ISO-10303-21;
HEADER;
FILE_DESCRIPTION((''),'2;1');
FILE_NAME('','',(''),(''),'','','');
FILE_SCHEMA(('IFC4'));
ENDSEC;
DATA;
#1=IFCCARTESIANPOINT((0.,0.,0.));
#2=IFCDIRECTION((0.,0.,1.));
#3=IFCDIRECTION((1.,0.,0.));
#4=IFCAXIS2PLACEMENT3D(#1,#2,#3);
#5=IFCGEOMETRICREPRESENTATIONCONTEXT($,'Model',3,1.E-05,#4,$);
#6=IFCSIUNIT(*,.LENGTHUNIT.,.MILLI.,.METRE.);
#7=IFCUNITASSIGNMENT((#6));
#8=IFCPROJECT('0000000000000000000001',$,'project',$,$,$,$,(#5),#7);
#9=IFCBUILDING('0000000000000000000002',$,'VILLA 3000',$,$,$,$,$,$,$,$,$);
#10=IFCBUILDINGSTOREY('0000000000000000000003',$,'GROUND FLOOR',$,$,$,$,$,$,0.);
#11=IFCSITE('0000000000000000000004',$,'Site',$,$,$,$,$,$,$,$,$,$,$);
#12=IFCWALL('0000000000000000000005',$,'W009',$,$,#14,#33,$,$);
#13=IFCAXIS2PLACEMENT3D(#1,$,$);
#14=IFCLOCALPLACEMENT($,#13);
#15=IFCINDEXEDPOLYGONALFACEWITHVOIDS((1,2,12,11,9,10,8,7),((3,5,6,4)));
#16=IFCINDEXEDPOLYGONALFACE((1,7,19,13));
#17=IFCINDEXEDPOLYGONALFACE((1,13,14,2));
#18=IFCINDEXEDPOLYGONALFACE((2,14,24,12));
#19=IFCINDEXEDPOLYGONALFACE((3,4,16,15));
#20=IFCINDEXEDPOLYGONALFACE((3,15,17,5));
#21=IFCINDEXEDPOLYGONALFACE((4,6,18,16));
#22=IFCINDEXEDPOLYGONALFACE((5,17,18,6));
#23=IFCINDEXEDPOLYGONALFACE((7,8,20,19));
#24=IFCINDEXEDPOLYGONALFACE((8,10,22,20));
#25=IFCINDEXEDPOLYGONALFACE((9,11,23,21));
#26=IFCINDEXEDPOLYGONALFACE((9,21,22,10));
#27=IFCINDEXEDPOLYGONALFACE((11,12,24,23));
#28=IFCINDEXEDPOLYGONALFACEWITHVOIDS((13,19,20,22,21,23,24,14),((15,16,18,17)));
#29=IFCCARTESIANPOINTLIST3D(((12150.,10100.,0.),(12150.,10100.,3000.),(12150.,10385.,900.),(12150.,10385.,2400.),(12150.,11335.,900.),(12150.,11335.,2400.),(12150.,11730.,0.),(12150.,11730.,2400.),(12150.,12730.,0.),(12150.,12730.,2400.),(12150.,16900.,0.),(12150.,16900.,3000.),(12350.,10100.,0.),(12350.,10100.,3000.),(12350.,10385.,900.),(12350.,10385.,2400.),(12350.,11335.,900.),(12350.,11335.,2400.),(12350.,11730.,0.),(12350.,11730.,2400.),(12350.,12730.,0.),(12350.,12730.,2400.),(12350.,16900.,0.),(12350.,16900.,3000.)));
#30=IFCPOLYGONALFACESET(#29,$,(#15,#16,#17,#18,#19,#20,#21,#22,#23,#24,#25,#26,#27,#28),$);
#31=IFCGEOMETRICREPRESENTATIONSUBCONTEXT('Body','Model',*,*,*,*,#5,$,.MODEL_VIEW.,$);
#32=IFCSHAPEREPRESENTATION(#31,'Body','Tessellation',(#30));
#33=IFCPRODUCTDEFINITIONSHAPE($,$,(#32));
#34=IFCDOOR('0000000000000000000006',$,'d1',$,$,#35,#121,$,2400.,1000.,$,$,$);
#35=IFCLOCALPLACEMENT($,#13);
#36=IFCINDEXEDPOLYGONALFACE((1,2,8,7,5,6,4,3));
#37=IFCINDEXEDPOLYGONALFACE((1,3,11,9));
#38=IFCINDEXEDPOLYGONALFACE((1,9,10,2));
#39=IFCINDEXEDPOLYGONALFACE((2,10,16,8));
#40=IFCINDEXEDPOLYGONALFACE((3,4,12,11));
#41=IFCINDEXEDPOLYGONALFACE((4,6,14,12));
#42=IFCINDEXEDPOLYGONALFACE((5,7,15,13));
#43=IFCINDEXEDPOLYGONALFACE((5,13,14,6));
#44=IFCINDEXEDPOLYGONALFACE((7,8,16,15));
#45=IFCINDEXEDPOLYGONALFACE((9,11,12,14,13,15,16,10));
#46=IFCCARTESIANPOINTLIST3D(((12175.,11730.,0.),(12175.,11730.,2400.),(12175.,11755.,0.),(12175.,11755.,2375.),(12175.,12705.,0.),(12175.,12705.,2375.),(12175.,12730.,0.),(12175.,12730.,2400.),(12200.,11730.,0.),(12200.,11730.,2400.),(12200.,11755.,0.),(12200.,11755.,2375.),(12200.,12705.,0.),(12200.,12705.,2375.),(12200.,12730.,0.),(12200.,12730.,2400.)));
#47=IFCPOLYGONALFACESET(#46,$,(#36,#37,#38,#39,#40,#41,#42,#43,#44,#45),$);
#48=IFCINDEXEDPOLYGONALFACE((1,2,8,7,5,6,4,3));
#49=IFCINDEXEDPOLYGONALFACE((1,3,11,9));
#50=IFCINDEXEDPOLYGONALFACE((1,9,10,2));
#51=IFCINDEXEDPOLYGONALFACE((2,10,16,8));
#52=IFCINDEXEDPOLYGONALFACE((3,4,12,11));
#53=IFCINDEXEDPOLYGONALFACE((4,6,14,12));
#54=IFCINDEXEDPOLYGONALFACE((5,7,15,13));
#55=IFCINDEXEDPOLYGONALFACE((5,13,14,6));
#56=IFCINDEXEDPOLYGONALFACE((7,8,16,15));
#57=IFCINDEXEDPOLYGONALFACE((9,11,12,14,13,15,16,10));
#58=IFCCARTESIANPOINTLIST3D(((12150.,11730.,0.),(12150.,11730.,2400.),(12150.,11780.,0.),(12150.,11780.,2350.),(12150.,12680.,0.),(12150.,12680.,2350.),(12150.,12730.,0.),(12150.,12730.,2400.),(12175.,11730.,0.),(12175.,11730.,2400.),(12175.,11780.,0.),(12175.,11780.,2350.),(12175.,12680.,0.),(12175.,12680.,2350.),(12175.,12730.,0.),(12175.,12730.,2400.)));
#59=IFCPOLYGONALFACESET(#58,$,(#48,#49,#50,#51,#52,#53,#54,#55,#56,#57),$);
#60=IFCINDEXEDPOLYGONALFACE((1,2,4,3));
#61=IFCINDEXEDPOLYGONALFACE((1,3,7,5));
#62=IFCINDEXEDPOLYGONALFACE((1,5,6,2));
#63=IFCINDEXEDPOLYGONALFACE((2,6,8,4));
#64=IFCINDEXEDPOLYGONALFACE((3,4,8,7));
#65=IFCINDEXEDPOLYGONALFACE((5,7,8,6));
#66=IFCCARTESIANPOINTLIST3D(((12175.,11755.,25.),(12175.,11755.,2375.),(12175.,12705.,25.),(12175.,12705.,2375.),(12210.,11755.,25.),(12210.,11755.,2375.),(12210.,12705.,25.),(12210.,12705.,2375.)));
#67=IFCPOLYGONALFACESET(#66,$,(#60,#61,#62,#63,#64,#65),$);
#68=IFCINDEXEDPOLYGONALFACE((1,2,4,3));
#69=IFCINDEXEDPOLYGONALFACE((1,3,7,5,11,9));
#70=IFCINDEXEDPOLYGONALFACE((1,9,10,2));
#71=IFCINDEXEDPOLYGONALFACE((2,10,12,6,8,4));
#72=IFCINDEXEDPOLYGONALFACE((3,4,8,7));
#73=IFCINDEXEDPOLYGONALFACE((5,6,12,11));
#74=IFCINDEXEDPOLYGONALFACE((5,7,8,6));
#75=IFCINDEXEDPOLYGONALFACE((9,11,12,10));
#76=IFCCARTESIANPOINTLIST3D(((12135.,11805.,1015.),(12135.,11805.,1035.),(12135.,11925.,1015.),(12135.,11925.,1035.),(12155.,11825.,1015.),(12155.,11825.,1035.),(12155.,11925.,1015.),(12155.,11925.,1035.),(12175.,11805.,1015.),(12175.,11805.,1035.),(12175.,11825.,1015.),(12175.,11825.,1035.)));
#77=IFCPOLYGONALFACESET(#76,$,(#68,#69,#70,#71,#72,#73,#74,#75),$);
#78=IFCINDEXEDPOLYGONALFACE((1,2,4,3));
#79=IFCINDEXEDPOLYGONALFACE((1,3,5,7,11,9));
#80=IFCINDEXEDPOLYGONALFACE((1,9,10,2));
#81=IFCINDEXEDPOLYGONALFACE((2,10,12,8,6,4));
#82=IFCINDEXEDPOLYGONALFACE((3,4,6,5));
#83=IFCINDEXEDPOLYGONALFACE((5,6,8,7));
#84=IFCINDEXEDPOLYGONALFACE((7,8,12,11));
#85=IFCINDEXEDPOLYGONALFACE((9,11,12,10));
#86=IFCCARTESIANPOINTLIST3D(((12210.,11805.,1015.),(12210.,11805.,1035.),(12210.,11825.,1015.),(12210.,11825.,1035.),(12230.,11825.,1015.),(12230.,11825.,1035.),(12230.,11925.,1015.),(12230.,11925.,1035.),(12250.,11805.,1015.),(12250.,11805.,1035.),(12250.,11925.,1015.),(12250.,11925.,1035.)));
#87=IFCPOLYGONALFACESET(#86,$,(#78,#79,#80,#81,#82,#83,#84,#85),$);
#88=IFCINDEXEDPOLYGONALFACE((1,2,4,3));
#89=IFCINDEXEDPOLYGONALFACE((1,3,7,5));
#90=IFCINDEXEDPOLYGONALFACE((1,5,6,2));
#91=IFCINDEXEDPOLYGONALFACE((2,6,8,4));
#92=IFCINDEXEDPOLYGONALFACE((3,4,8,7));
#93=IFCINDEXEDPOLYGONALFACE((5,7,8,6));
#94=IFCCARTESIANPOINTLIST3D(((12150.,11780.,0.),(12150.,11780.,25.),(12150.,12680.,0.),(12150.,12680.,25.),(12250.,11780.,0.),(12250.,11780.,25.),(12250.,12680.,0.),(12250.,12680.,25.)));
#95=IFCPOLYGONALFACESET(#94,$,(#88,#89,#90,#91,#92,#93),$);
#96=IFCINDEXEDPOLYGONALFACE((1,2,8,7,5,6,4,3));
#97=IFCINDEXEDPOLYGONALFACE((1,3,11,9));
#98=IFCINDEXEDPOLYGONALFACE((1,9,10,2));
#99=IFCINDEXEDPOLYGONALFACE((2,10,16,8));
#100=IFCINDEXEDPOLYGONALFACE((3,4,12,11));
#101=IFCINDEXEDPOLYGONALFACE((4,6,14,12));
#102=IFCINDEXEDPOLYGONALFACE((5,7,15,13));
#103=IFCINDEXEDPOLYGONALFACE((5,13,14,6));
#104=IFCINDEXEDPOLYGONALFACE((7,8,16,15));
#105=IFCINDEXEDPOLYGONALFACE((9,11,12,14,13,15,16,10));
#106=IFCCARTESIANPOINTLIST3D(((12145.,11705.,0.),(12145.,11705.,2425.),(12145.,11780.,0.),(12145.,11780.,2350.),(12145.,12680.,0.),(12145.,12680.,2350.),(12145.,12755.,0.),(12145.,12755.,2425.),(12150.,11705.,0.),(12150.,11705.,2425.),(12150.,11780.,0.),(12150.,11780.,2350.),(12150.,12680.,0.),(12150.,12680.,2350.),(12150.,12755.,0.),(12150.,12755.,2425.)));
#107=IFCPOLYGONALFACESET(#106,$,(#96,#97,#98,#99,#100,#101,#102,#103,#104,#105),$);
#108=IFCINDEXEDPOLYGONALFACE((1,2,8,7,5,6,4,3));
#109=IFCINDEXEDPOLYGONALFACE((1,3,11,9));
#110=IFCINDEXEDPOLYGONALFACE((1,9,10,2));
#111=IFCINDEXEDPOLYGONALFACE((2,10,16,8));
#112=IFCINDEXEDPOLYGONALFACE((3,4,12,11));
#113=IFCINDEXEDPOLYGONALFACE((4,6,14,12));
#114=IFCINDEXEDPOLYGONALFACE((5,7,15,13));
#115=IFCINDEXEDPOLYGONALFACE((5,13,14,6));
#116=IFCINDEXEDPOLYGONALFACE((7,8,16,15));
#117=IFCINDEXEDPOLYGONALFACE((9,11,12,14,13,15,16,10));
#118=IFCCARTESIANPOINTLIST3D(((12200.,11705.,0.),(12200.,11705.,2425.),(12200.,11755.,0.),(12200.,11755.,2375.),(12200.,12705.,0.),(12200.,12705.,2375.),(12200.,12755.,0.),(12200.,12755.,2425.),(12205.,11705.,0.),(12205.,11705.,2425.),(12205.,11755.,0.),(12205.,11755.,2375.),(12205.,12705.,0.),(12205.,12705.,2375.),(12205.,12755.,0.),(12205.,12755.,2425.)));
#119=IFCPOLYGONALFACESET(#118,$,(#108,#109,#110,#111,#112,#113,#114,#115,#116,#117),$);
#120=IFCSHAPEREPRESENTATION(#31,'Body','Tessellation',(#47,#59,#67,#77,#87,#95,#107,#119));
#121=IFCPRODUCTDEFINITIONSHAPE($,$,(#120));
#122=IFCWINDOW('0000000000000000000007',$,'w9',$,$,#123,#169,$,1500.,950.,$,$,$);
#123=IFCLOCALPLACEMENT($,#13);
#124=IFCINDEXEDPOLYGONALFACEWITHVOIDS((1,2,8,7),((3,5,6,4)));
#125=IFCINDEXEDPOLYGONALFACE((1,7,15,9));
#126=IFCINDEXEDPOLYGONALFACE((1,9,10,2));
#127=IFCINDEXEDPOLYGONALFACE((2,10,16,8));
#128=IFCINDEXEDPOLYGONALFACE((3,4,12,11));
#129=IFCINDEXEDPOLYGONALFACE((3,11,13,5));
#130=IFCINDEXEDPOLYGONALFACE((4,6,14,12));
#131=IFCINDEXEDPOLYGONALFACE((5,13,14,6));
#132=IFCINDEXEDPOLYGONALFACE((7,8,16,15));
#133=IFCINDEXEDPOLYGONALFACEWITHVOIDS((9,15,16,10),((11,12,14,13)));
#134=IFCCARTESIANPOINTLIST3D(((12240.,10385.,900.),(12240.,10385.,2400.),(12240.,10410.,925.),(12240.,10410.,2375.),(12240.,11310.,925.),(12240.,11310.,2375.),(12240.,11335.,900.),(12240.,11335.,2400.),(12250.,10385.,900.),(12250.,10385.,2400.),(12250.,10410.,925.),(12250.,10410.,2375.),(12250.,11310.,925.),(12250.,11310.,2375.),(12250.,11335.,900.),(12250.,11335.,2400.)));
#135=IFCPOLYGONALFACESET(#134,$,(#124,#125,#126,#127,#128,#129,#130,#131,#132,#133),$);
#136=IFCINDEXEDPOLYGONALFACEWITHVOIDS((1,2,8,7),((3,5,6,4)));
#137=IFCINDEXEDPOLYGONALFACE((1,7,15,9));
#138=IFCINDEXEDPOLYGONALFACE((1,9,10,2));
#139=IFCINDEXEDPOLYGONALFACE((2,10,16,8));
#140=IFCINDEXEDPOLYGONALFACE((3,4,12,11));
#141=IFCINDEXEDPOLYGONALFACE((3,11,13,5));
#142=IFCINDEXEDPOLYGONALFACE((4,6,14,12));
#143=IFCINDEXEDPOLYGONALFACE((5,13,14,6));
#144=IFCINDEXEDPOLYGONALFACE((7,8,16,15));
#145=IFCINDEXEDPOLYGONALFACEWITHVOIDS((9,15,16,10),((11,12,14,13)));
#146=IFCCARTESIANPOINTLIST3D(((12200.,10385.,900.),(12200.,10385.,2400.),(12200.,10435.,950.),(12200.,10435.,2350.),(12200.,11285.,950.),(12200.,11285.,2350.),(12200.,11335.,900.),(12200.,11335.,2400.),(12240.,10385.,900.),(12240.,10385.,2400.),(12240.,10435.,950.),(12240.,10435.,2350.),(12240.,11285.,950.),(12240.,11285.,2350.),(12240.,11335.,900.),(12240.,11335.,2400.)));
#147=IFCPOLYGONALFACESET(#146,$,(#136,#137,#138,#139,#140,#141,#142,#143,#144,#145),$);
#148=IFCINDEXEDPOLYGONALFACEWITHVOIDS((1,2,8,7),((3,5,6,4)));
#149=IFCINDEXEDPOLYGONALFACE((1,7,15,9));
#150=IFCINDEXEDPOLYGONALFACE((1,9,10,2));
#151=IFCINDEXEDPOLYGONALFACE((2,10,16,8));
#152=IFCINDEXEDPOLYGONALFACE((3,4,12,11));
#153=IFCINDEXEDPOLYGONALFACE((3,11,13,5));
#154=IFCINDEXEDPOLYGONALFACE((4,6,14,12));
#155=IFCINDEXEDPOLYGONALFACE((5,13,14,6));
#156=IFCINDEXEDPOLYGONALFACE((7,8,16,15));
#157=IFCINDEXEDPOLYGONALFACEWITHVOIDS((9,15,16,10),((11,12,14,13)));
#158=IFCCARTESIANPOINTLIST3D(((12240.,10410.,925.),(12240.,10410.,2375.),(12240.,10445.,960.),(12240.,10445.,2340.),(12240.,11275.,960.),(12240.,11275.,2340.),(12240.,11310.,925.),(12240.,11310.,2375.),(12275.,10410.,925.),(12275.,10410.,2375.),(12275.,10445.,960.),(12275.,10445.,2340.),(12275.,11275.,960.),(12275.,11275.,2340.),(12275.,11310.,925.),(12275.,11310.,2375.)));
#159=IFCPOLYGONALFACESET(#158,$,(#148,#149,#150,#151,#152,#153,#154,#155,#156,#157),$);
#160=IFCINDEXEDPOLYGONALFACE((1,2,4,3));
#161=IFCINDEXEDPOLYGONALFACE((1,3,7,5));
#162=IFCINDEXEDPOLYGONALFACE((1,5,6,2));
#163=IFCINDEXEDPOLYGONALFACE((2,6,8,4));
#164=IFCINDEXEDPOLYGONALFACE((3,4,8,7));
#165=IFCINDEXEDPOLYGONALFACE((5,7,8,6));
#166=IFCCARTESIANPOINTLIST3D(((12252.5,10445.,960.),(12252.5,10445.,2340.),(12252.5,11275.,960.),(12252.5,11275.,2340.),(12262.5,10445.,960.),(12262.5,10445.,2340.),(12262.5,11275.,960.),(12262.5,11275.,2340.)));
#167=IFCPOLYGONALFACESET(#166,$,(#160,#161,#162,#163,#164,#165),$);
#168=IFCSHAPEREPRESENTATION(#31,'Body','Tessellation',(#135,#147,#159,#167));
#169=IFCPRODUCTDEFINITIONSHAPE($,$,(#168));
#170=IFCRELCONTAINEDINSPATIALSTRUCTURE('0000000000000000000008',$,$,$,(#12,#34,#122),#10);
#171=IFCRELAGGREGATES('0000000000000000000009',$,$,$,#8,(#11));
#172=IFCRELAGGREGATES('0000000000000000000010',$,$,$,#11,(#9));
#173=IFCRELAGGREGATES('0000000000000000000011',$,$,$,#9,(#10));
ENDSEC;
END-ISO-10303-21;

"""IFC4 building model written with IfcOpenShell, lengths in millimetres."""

from ifc_helpers import new_model, si_unit, frame, origin_with_axes, place, context, subcontext, project, spatial, line, indexed_curve, outline, extrude, element, fill, save


model = new_model("IFC4")

# Units and contexts
model_context = context("Model", 3, precision=1e-05, world=origin_with_axes())
body_context = subcontext(model_context, "Body", "Model", "MODEL_VIEW")
ifc_project = project(units=[si_unit("LENGTHUNIT", "METRE", prefix="MILLI")], contexts=[model_context])

# Site, building, storey
site = spatial("IfcSite", under=ifc_project, Name="Site")
building = spatial("IfcBuilding", under=site, Name="VILLA 3000")
storey = spatial("IfcBuildingStorey", under=building, Name="GROUND FLOOR", Elevation=0.0)

# Wall, openings, door, window
wall_1_placement = place(None, frame((12250.0, 16900.0, 0.0), z_axis=(0.0, 0.0, 1.0), x_axis=(0.0, -1.0, 0.0)))
wall_1 = element("IfcWall", 1, at=wall_1_placement, inside=storey, Name="W009", context=body_context, shape_type="SweptSolid", body=[
    extrude(outline(indexed_curve([(0.0, 0.0), (0.0, 200.0), (6800.0, 200.0), (6800.0, 0.0), (0.0, 0.0)], self_intersect=False)), frame((0.0, -100.0, 0.0), z_axis=(0.0, 0.0, 1.0), x_axis=(1.0, 0.0, 0.0)), (0.0, 0.0, 1.0), 3000.0),
])
opening_1_placement = place(wall_1_placement, frame((4170.0, 0.0, 0.0), z_axis=(0.0, 0.0, 1.0), x_axis=(1.0, 0.0, 0.0)))
opening_1 = element("IfcOpeningElement", 2, at=opening_1_placement, cuts=wall_1, context=body_context, shape_type="SweptSolid", body=[
    extrude(outline(indexed_curve([(0.0, 0.0), (0.0, 300.0), (1000.0, 300.0), (1000.0, 0.0), (0.0, 0.0)], self_intersect=False)), frame((0.0, -150.0, 0.0), z_axis=(0.0, 0.0, 1.0), x_axis=(1.0, 0.0, 0.0)), (0.0, 0.0, 1.0), 2400.0),
])
opening_2_placement = place(wall_1_placement, frame((5565.0, 0.0, 900.0), z_axis=(0.0, 0.0, 1.0), x_axis=(1.0, 0.0, 0.0)))
opening_2 = element("IfcOpeningElement", 3, at=opening_2_placement, cuts=wall_1, context=body_context, shape_type="SweptSolid", body=[
    extrude(outline(indexed_curve([(0.0, 0.0), (0.0, 300.0), (950.0, 300.0), (950.0, 0.0), (0.0, 0.0)], self_intersect=False)), frame((0.0, -150.0, 0.0), z_axis=(0.0, 0.0, 1.0), x_axis=(1.0, 0.0, 0.0)), (0.0, 0.0, 1.0), 1500.0),
])
door_1_placement = place(None, frame((12150.0, 12730.0, 0.0), z_axis=(0.0, 0.0, 1.0), x_axis=(0.0, -1.0, 0.0)))
door_1 = element("IfcDoor", 4, at=door_1_placement, inside=storey, Name="d1", OverallHeight=2400.0, OverallWidth=1000.0, context=body_context, shape_type="SweptSolid", body=[
    extrude(outline(indexed_curve([(0.0, 0.0), (0.0, 2400.0), (1000.0, 2400.0), (1000.0, 0.0), (975.0, 0.0), (975.0, 2375.0), (25.0, 2375.0), (25.0, 0.0)], segments=[line(1, 2, 3, 4, 5, 6, 7, 8, 1)])), frame((0.0, 25.0, 0.0), z_axis=(0.0, -1.0, 0.0), x_axis=(1.0, 0.0, 0.0)), (0.0, 0.0, -1.0), 25.0),
    extrude(outline(indexed_curve([(0.0, 0.0), (0.0, 2400.0), (1000.0, 2400.0), (1000.0, 0.0), (950.0, 0.0), (950.0, 2350.0), (50.0, 2350.0), (50.0, 0.0)], segments=[line(1, 2, 3, 4, 5, 6, 7, 8, 1)])), frame((0.0, 0.0, 0.0), z_axis=(0.0, -1.0, 0.0), x_axis=(1.0, 0.0, 0.0)), (0.0, 0.0, -1.0), 25.0),
    extrude(outline(indexed_curve([(0.0, 0.0), (950.0, 0.0), (950.0, 35.0), (0.0, 35.0)], segments=[line(1, 2, 3, 4, 1)])), frame((25.0, 25.0, 25.0), z_axis=(0.0, 0.0, 1.0), x_axis=(1.0, 0.0, 0.0)), (0.0, 0.0, 1.0), 2350.0),
    extrude(outline(indexed_curve([(0.0, 0.0), (0.0, -40.0), (-120.0, -40.0), (-120.0, -20.0), (-20.0, -20.0), (-20.0, 0.0)], segments=[line(1, 2, 3, 4, 5, 6, 1)])), frame((925.0, 25.0, 1015.0), z_axis=(0.0, 0.0, 1.0), x_axis=(1.0, 0.0, 0.0)), (0.0, 0.0, 1.0), 20.0),
    extrude(outline(indexed_curve([(0.0, 0.0), (0.0, 40.0), (-120.0, 40.0), (-120.0, 20.0), (-20.0, 20.0), (-20.0, 0.0)], segments=[line(1, 2, 3, 4, 5, 6, 1)])), frame((925.0, 60.0, 1015.0), z_axis=(0.0, 0.0, 1.0), x_axis=(1.0, 0.0, 0.0)), (0.0, 0.0, 1.0), 20.0),
    extrude(outline(indexed_curve([(0.0, 0.0), (900.0, 0.0), (900.0, 100.0), (0.0, 100.0)], segments=[line(1, 2, 3, 4, 1)])), frame((50.0, 0.0, 0.0), z_axis=(0.0, 0.0, 1.0), x_axis=(1.0, 0.0, 0.0)), (0.0, 0.0, 1.0), 25.0),
    extrude(outline(indexed_curve([(0.0, 0.0), (0.0, 2425.0), (1050.0, 2425.0), (1050.0, 0.0), (975.0, 0.0), (975.0, 2350.0), (75.0, 2350.0), (75.0, 0.0)], segments=[line(1, 2, 3, 4, 5, 6, 7, 8, 1)])), frame((-25.0, -5.0, 0.0), z_axis=(0.0, -1.0, 0.0), x_axis=(1.0, 0.0, 0.0)), (0.0, 0.0, -1.0), 5.0),
    extrude(outline(indexed_curve([(0.0, 0.0), (0.0, 2425.0), (1050.0, 2425.0), (1050.0, 0.0), (1000.0, 0.0), (1000.0, 2375.0), (50.0, 2375.0), (50.0, 0.0)], segments=[line(1, 2, 3, 4, 5, 6, 7, 8, 1)])), frame((-25.0, 50.0, 0.0), z_axis=(0.0, -1.0, 0.0), x_axis=(1.0, 0.0, 0.0)), (0.0, 0.0, -1.0), 5.0),
])
fill(opening_1, door_1)
window_1_placement = place(None, frame((12150.0, 11335.0, 900.0), z_axis=(0.0, 0.0, 1.0), x_axis=(0.0, -1.0, 0.0)))
window_1 = element("IfcWindow", 5, at=window_1_placement, inside=storey, Name="w9", OverallHeight=1500.0, OverallWidth=950.0, context=body_context, shape_type="SweptSolid", body=[
    extrude(outline(indexed_curve([(0.0, 0.0), (950.0, 0.0), (950.0, 1500.0), (0.0, 1500.0)], segments=[line(1, 2, 3, 4, 1)]), holes=[indexed_curve([(25.0, 25.0), (925.0, 25.0), (925.0, 1475.0), (25.0, 1475.0)], segments=[line(1, 2, 3, 4, 1)])]), frame((0.0, 90.0, 0.0), z_axis=(0.0, -1.0, 0.0), x_axis=(1.0, 0.0, 0.0)), (0.0, 0.0, -1.0), 10.0),
    extrude(outline(indexed_curve([(0.0, 0.0), (950.0, 0.0), (950.0, 1500.0), (0.0, 1500.0)], segments=[line(1, 2, 3, 4, 1)]), holes=[indexed_curve([(50.0, 50.0), (900.0, 50.0), (900.0, 1450.0), (50.0, 1450.0)], segments=[line(1, 2, 3, 4, 1)])]), frame((0.0, 50.0, 0.0), z_axis=(0.0, -1.0, 0.0), x_axis=(1.0, 0.0, 0.0)), (0.0, 0.0, -1.0), 40.0),
    extrude(outline(indexed_curve([(0.0, 0.0), (900.0, 0.0), (900.0, 1450.0), (0.0, 1450.0)], segments=[line(1, 2, 3, 4, 1)]), holes=[indexed_curve([(35.0, 35.0), (865.0, 35.0), (865.0, 1415.0), (35.0, 1415.0)], segments=[line(1, 2, 3, 4, 1)])]), frame((25.0, 90.0, 25.0), z_axis=(0.0, -1.0, 0.0), x_axis=(1.0, 0.0, 0.0)), (0.0, 0.0, -1.0), 35.0),
    extrude(outline(indexed_curve([(35.0, 35.0), (865.0, 35.0), (865.0, 1415.0), (35.0, 1415.0)], segments=[line(1, 2, 3, 4, 1)])), frame((25.0, 102.5, 25.0), z_axis=(0.0, -1.0, 0.0), x_axis=(1.0, 0.0, 0.0)), (0.0, 0.0, -1.0), 10.0),
])
fill(opening_2, window_1)

save(model, "model.ifc")
